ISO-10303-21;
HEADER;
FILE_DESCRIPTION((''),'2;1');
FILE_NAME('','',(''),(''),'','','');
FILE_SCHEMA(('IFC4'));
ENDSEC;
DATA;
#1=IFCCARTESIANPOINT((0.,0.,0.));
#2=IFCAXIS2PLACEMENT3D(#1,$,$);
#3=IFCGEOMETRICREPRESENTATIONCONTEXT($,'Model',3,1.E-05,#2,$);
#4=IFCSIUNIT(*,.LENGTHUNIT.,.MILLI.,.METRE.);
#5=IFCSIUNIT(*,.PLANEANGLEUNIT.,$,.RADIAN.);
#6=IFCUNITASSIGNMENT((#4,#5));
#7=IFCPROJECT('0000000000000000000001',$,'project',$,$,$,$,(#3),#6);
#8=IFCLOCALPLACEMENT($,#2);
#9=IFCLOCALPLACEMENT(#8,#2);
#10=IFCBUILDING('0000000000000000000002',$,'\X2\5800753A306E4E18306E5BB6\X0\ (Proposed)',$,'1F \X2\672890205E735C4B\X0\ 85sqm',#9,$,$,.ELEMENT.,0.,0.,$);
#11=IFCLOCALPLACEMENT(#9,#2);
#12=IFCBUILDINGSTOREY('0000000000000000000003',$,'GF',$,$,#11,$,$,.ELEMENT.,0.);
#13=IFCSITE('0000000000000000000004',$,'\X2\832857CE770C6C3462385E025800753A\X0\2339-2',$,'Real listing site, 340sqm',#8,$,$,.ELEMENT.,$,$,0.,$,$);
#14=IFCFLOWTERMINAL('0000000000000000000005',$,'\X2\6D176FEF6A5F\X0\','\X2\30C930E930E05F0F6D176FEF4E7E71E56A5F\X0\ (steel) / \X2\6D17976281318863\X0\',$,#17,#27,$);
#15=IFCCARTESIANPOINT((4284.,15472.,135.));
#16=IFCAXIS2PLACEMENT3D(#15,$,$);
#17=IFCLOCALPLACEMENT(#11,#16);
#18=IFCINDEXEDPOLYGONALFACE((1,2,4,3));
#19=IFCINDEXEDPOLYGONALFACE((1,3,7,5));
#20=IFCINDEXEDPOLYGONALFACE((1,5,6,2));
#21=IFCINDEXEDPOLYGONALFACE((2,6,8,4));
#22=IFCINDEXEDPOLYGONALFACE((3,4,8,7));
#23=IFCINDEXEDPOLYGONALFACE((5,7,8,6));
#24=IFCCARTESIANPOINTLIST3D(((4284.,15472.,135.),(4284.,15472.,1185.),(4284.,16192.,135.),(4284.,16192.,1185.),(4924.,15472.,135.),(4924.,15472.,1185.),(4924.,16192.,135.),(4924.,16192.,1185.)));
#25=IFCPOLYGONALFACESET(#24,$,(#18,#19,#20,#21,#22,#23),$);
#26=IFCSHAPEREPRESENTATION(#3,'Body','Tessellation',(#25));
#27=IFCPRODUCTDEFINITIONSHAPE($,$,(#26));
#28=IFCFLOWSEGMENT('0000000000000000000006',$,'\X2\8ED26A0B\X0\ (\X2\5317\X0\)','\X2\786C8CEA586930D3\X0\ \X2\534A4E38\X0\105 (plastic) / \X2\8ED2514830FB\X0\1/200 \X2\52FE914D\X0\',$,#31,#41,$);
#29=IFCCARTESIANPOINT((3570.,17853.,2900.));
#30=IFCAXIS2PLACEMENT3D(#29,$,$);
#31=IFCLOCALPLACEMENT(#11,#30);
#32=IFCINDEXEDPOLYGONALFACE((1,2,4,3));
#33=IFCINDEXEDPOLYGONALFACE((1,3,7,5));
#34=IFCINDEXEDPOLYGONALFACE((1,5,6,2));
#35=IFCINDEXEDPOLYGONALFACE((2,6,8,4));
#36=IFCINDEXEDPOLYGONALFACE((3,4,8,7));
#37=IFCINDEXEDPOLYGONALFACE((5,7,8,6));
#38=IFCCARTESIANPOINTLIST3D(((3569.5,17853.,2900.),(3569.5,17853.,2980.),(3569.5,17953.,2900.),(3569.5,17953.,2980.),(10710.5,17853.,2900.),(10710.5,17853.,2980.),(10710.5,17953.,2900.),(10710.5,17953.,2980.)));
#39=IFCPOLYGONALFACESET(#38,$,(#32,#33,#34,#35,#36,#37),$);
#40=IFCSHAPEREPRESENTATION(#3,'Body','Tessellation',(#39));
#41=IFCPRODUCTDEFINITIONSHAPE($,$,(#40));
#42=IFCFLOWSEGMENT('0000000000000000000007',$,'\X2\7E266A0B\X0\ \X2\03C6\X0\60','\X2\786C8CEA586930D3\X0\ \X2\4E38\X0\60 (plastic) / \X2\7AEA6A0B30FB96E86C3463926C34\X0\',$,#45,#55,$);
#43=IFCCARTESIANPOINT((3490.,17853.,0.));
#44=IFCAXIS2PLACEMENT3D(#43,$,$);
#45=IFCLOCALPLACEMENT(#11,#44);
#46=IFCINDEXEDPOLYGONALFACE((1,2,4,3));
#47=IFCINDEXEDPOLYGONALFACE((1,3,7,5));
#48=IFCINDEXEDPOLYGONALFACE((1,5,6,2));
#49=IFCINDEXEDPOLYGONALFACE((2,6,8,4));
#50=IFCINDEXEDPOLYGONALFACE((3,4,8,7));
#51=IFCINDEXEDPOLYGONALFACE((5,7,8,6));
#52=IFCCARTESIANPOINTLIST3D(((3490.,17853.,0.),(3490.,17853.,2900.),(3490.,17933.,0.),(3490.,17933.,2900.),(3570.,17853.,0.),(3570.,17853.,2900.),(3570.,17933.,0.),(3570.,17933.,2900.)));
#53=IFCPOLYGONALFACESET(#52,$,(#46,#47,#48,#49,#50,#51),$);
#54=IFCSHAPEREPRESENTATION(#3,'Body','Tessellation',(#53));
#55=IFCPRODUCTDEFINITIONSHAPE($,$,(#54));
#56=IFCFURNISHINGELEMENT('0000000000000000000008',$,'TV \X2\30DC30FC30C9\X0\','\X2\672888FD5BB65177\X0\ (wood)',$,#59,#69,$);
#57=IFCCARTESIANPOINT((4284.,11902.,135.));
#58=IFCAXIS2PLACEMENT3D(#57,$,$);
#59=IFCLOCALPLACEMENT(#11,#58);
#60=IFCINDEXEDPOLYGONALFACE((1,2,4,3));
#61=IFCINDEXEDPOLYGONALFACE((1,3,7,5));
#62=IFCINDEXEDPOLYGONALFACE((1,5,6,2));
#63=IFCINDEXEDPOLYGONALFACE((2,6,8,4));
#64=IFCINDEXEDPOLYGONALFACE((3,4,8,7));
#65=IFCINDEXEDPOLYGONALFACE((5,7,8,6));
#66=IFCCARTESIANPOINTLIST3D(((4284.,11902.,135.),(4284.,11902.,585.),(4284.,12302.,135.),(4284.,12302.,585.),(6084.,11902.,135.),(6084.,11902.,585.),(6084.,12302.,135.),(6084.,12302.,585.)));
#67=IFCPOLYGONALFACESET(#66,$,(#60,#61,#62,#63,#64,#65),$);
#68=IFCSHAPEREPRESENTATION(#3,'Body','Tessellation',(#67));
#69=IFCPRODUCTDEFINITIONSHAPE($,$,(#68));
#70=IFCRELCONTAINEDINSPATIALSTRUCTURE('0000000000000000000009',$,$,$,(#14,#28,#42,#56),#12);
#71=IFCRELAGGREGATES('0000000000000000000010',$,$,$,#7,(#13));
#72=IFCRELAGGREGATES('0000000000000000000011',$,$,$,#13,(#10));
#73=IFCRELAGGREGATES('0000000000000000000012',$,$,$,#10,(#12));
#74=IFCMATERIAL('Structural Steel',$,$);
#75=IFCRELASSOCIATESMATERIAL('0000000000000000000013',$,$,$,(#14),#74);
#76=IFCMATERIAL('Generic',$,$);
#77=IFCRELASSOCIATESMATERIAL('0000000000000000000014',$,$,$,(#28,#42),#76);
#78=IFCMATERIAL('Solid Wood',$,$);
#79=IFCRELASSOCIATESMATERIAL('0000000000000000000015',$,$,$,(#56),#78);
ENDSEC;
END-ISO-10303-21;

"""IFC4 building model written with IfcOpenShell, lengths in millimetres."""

from ifc_helpers import new_model, si_unit, frame, frame_2d, origin, place, context, project, spatial, rectangle, extrude, material, element, save


model = new_model("IFC4")

# Units and contexts
model_context = context("Model", 3, precision=1e-05, world=origin())
ifc_project = project(units=[si_unit("LENGTHUNIT", "METRE", prefix="MILLI"), si_unit("PLANEANGLEUNIT", "RADIAN")], contexts=[model_context])

# Site, building, storey
site_placement = place(None, origin())
site = spatial("IfcSite", under=ifc_project, at=site_placement, Name="茨城県水戸市堀町2339-2", ObjectType="Real listing site, 340sqm", CompositionType="ELEMENT", RefElevation=0.0)
building_placement = place(site_placement, origin())
building = spatial("IfcBuilding", under=site, at=building_placement, Name="堀町の丘の家 (Proposed)", ObjectType="1F 木造平屋 85sqm", CompositionType="ELEMENT", ElevationOfRefHeight=0.0, ElevationOfTerrain=0.0)
storey_placement = place(building_placement, origin())
storey = spatial("IfcBuildingStorey", under=building, at=storey_placement, Name="GF", CompositionType="ELEMENT", Elevation=0.0)

# Shared definitions
ifc_material_1 = material(Name="Solid Wood")

# Shared definitions
ifc_material_2 = material(Name="Structural Steel")

# Shared definitions
ifc_material_3 = material(Name="Generic")

# Flow terminal
flow_terminal_placement = place(storey_placement, frame((4284.0, 15472.0, 135.0)))
element("IfcFlowTerminal", 1, at=flow_terminal_placement, inside=storey, material=ifc_material_2, Name="洗濯機", Description="ドラム式洗濯乾燥機 (steel) / 洗面脱衣", context=model_context, shape_type="SweptSolid", body=[
    extrude(rectangle(XDim=640.0, YDim=720.0, at=frame_2d((320.0, 360.0))), frame((4284.0, 15472.0, 135.0)), (0.0, 0.0, 1.0), 1050.0),
])

# Flow segments
flow_segment_1_placement = place(storey_placement, frame((3570.0, 17853.0, 2900.0)))
element("IfcFlowSegment", 2, at=flow_segment_1_placement, inside=storey, material=ifc_material_3, Name="軒樋 (北)", Description="硬質塩ビ 半丸105 (plastic) / 軒先・1/200 勾配", context=model_context, shape_type="SweptSolid", body=[
    extrude(rectangle(XDim=7141.0, YDim=100.0, at=frame_2d((3570.0, 50.0))), frame((3570.0, 17853.0, 2900.0)), (0.0, 0.0, 1.0), 80.0),
])
flow_segment_2_placement = place(storey_placement, frame((3490.0, 17853.0, 0.0)))
element("IfcFlowSegment", 3, at=flow_segment_2_placement, inside=storey, material=ifc_material_3, Name="縦樋 φ60", Description="硬質塩ビ 丸60 (plastic) / 竪樋・雨水排水", context=model_context, shape_type="SweptSolid", body=[
    extrude(rectangle(XDim=80.0, YDim=80.0, at=frame_2d((40.0, 40.0))), frame((3490.0, 17853.0, 0.0)), (0.0, 0.0, 1.0), 2900.0),
])

# Furnishing element
furnishing_placement = place(storey_placement, frame((4284.0, 11902.0, 135.0)))
element("IfcFurnishingElement", 4, at=furnishing_placement, inside=storey, material=ifc_material_1, Name="TV ボード", Description="木製家具 (wood)", context=model_context, shape_type="SweptSolid", body=[
    extrude(rectangle(XDim=1800.0, YDim=400.0, at=frame_2d((900.0, 200.0))), frame((4284.0, 11902.0, 135.0)), (0.0, 0.0, 1.0), 450.0),
])

save(model, "model.ifc")
